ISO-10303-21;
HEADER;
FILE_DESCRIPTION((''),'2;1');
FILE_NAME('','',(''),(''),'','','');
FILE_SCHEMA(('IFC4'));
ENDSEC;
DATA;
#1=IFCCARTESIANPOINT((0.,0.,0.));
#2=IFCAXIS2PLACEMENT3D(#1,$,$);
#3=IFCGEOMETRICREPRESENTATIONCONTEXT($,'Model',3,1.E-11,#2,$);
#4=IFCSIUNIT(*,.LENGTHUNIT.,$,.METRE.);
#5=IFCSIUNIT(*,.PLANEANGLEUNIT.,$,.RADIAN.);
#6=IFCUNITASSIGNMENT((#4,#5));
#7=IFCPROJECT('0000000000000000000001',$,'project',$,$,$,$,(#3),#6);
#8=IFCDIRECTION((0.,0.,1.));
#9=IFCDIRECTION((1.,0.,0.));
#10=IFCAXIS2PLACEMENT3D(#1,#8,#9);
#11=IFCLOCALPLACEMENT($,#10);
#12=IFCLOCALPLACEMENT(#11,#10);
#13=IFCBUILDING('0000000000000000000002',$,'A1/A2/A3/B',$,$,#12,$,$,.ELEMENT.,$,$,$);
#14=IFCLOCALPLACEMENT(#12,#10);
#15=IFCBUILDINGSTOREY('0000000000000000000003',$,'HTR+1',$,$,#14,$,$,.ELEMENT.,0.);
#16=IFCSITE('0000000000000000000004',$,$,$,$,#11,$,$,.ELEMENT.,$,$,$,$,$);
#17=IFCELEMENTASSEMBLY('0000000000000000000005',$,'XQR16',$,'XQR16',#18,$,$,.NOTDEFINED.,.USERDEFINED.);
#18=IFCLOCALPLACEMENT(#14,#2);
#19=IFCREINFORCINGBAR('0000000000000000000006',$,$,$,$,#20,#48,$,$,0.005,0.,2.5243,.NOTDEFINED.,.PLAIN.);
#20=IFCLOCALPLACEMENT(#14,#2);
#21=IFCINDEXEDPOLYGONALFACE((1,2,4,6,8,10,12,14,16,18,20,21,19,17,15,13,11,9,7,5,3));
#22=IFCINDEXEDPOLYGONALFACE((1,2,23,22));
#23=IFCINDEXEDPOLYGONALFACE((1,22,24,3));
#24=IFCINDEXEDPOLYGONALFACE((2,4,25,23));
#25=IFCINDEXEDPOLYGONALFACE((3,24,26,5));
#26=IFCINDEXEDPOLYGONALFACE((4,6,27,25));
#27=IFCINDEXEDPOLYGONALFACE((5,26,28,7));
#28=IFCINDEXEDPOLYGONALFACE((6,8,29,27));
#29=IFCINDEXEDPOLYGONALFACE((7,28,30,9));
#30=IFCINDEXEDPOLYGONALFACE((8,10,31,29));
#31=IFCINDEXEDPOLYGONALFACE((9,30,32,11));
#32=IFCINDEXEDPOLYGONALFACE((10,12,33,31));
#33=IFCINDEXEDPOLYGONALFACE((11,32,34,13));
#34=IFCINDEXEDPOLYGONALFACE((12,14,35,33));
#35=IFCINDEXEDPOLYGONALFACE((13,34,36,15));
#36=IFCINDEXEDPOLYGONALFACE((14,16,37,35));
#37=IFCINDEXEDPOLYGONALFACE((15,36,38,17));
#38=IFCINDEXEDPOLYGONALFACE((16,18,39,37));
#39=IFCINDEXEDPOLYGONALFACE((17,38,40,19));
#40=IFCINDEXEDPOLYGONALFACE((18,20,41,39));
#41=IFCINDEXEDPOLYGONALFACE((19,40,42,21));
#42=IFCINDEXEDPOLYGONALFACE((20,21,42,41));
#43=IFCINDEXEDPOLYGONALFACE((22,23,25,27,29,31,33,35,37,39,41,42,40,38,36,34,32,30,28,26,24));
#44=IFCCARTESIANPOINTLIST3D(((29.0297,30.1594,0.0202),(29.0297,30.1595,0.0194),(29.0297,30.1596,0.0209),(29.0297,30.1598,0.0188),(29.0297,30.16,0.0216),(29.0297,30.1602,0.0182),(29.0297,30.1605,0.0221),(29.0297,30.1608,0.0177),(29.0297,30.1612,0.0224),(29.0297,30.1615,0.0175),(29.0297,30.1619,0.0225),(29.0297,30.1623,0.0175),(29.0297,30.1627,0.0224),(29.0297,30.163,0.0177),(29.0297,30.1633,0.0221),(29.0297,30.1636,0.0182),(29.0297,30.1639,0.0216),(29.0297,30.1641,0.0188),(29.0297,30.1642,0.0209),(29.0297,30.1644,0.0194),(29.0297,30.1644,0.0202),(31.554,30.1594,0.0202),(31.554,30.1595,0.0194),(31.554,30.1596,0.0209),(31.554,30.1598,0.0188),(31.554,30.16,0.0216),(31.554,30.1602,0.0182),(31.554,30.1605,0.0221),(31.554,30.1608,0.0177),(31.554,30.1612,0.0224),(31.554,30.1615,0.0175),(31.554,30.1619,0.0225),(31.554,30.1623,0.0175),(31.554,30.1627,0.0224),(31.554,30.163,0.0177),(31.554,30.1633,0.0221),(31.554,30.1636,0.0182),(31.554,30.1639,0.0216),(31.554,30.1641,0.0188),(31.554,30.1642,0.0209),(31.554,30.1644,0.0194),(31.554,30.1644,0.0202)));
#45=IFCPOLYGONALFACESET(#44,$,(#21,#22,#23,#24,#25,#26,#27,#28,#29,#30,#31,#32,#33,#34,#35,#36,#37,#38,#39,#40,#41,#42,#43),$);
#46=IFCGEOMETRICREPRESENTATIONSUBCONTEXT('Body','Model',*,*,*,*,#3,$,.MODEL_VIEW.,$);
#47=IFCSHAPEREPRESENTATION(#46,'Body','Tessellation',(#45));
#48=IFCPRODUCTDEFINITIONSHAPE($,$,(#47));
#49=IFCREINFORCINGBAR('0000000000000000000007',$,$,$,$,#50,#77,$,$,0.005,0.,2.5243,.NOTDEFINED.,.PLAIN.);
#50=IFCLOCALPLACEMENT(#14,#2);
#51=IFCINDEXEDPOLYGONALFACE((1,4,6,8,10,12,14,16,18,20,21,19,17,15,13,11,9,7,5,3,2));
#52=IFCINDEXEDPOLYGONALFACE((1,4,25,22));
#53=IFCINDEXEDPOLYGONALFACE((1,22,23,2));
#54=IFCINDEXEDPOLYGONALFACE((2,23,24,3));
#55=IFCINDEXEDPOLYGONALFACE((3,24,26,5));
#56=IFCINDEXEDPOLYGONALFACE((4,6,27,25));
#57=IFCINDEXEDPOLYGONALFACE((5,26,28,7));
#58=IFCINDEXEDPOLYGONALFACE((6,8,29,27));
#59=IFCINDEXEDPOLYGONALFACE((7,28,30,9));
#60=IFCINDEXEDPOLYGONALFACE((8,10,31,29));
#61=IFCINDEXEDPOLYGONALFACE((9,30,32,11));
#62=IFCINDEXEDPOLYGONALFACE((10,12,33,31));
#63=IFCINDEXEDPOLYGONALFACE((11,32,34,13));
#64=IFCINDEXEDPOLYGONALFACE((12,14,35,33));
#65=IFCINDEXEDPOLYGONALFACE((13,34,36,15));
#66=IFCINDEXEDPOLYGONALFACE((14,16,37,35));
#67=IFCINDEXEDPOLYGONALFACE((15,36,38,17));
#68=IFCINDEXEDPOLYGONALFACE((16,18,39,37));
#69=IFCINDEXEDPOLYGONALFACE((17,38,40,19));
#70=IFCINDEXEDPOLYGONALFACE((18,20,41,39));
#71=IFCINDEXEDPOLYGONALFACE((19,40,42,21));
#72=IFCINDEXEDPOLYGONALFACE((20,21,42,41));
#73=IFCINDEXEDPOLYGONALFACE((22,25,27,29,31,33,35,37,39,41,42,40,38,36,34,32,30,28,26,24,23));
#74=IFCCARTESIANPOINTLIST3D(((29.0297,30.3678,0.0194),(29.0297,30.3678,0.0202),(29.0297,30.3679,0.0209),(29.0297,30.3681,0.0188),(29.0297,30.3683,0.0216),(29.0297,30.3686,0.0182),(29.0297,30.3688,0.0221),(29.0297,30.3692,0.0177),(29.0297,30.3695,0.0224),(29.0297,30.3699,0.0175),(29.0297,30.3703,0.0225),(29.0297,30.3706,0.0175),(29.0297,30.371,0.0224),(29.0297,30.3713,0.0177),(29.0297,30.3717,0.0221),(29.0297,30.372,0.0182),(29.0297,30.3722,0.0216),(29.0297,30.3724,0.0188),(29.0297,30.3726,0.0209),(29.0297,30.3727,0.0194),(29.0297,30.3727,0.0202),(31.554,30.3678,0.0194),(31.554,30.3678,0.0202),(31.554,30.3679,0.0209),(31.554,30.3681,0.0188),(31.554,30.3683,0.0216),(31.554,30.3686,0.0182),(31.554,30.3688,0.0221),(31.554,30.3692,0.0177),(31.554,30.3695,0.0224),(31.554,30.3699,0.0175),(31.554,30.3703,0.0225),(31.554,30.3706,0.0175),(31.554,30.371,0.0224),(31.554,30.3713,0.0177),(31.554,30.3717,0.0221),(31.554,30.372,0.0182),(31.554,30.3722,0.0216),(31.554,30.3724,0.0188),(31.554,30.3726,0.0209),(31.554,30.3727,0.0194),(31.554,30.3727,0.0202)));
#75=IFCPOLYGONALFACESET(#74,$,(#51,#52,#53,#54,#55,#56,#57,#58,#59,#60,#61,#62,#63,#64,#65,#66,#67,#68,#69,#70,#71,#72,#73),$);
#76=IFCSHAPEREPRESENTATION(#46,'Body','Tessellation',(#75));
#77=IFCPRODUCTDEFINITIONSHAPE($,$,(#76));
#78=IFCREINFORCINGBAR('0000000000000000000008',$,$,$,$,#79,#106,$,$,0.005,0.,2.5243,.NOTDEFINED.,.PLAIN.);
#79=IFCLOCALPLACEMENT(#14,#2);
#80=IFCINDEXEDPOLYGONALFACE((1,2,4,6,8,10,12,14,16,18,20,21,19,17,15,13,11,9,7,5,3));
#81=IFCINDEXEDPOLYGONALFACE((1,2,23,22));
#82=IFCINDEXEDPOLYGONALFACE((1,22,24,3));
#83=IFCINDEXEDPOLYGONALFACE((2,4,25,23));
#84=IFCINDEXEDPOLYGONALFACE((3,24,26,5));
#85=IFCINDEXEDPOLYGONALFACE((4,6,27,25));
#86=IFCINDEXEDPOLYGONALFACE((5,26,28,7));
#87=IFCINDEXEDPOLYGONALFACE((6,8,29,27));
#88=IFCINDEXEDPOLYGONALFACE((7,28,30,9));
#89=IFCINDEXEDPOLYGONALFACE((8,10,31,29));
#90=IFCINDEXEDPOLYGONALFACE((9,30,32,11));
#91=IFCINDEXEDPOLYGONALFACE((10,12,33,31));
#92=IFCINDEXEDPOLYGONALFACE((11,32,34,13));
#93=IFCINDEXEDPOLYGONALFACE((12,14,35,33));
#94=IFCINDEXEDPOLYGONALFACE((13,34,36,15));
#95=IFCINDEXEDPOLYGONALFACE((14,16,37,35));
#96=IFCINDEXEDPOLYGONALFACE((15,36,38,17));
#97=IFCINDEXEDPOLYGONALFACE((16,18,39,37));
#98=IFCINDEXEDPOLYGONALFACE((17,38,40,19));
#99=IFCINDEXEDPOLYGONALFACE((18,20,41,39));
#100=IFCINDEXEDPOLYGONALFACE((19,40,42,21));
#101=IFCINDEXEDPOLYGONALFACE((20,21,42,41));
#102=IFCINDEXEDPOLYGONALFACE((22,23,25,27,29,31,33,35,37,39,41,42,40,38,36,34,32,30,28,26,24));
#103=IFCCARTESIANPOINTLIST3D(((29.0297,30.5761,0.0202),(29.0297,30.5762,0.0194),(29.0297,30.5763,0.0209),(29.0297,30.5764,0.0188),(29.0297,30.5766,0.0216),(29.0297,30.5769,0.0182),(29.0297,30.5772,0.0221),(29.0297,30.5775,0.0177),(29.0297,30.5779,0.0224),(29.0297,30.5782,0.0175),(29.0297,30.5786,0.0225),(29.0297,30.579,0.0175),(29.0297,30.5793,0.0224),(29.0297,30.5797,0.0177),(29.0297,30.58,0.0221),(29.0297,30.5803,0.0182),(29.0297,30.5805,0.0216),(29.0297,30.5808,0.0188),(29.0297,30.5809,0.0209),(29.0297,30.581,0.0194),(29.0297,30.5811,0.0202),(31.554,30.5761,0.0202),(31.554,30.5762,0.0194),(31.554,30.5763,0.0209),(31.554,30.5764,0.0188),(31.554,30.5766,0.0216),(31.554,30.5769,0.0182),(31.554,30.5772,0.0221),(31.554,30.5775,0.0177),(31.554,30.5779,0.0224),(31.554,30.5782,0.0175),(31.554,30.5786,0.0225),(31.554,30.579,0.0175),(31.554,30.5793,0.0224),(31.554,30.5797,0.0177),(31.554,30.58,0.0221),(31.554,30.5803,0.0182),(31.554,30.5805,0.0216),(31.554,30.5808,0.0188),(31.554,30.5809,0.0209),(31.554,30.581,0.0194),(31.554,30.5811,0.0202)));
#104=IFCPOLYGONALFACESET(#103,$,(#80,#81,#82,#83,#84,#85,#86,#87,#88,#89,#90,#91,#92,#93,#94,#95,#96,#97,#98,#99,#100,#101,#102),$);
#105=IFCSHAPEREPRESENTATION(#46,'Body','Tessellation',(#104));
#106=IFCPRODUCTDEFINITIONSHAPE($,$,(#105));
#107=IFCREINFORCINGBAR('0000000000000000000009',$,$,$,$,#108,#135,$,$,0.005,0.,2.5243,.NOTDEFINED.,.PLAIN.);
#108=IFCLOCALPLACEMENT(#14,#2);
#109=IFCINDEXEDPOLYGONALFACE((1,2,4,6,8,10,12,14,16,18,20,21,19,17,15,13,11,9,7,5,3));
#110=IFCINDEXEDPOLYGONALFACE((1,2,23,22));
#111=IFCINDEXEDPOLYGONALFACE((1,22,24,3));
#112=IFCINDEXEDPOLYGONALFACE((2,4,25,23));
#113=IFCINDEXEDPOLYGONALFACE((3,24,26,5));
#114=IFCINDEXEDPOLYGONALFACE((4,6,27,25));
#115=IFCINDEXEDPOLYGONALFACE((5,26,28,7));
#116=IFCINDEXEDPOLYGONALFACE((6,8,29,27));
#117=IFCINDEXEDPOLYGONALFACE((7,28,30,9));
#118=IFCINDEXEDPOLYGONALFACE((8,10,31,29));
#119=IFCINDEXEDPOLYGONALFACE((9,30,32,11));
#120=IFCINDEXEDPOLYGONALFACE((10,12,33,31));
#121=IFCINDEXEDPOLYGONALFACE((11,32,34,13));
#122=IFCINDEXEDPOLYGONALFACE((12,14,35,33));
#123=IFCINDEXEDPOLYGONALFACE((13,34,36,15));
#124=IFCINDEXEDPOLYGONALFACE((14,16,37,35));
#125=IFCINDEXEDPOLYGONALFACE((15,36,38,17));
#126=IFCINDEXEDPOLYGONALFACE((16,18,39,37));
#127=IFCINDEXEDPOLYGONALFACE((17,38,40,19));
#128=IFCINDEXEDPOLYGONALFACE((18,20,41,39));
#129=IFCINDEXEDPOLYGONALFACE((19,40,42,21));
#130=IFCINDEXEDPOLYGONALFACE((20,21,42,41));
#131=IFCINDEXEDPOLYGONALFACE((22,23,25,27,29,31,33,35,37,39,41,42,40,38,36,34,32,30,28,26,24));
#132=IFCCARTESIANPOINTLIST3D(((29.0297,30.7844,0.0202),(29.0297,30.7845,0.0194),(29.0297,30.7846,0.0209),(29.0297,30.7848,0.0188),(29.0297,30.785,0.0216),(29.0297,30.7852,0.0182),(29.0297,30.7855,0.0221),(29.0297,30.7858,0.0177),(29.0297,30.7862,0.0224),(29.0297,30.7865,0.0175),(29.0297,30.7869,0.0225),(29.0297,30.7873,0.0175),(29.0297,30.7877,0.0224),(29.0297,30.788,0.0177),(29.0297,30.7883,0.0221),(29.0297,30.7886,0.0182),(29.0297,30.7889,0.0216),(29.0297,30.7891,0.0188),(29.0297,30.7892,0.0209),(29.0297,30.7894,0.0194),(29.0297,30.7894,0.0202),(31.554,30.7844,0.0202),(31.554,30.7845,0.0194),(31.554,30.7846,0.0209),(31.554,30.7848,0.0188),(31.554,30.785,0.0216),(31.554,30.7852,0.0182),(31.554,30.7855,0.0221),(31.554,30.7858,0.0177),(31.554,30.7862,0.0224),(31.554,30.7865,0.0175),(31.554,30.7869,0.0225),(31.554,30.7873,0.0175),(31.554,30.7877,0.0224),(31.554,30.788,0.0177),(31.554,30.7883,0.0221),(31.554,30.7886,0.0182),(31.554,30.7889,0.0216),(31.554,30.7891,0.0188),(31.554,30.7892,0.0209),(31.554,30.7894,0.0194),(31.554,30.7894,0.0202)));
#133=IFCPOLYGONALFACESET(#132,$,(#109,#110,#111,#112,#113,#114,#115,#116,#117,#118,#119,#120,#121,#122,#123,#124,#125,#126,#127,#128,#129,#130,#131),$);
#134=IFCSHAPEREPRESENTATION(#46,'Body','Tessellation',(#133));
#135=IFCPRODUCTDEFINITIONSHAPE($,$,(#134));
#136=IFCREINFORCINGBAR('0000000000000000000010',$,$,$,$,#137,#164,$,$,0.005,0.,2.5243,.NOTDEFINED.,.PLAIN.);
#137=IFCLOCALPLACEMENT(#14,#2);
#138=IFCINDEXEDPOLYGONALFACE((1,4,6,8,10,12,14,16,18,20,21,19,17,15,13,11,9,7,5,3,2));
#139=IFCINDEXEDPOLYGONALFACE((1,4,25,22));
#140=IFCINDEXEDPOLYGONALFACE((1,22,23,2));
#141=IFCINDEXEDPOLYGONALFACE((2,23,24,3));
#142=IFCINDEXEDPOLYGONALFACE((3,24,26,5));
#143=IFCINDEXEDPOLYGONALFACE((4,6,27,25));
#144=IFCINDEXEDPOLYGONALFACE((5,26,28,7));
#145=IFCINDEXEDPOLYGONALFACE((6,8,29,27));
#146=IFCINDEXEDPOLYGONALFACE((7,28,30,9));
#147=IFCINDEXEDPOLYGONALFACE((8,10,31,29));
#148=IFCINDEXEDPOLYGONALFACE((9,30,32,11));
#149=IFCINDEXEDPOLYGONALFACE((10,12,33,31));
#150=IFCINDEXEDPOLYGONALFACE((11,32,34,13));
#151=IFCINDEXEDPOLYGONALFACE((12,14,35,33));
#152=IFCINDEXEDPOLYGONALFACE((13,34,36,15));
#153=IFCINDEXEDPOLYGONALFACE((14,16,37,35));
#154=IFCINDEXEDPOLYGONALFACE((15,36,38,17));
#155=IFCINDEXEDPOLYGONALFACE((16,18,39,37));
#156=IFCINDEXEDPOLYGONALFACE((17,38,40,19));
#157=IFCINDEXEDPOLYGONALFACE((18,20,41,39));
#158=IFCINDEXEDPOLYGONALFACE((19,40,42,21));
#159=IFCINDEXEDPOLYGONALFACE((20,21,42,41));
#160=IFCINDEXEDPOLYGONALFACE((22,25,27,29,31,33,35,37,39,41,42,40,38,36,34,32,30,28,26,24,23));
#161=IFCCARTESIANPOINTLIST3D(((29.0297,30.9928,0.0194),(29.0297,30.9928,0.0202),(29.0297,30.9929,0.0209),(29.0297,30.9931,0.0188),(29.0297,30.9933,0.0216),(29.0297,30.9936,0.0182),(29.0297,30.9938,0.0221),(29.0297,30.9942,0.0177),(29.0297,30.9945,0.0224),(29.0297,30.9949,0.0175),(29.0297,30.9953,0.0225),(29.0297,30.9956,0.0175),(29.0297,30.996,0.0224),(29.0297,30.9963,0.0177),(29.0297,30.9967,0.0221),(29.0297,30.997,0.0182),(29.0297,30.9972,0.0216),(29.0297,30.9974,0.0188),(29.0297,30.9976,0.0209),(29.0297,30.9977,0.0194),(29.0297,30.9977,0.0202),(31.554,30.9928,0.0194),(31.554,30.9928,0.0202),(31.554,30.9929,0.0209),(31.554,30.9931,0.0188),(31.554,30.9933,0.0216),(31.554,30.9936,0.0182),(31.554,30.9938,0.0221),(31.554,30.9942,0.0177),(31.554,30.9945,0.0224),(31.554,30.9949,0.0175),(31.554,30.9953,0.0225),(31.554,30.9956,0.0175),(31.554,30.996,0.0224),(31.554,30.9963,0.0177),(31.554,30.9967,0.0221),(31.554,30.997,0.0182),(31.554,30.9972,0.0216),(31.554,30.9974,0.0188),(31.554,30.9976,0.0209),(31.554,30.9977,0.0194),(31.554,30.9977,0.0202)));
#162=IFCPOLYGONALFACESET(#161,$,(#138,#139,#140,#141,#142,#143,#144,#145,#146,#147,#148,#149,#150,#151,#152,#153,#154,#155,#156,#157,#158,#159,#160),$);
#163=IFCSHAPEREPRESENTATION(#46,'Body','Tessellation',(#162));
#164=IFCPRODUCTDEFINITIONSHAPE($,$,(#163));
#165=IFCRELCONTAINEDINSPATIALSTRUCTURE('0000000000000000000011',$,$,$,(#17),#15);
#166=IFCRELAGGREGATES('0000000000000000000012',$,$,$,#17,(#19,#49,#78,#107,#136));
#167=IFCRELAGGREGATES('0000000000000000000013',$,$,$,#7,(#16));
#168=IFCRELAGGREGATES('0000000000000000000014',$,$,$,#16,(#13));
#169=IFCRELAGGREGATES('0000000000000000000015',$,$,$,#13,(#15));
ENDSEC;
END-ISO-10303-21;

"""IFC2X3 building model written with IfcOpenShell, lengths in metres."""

from ifc_helpers import new_model, entity, si_unit, origin, origin_with_axes, place, context, subcontext, project, spatial, shape, element, aggregate, save


model = new_model("IFC2X3")

# Units and contexts
model_context = context("Model", 3, precision=1e-11, world=origin())
body_context = subcontext(model_context, "Body", "Model", "MODEL_VIEW")
ifc_project = project(units=[si_unit("LENGTHUNIT", "METRE"), si_unit("PLANEANGLEUNIT", "RADIAN")], contexts=[model_context])

# Site, building, storey
site_placement = place(None, origin_with_axes())
site = spatial("IfcSite", under=ifc_project, at=site_placement, CompositionType="ELEMENT")
building_placement = place(site_placement, origin_with_axes())
building = spatial("IfcBuilding", under=site, at=building_placement, Name="A1/A2/A3/B", CompositionType="ELEMENT")
storey_placement = place(building_placement, origin_with_axes())
storey = spatial("IfcBuildingStorey", under=building, at=storey_placement, Name="HTR+1", CompositionType="ELEMENT", Elevation=0.0)

# Element assembly, reinforcing bars
assembly_1_placement = place(storey_placement, origin_with_axes())
assembly_1 = element("IfcElementAssembly", 1, at=assembly_1_placement, inside=storey, Name="XQR16", ObjectType="XQR16", AssemblyPlace="NOTDEFINED", PredefinedType="USERDEFINED")
reinforcing_bar_1_placement = place(assembly_1_placement, origin_with_axes())
reinforcing_bar_1 = element("IfcReinforcingBar", 2, at=reinforcing_bar_1_placement, BarLength=2.5243, BarRole="NOTDEFINED", BarSurface="PLAIN", CrossSectionArea=0.0, NominalDiameter=0.005, shapes=[
    shape(body_context, "Body", "AdvancedSweptSolid", [entity("IfcSweptDiskSolid", entity("IfcPolyline", [entity("IfcCartesianPoint", [29.0297, 30.1619, 0.02]), entity("IfcCartesianPoint", [31.554, 30.1619, 0.02])]), 0.0025, None, 0.0, 2.5243)]),
    shape(body_context, "Body", "AdvancedSweptSolid", [entity("IfcSweptDiskSolid", entity("IfcPolyline", [entity("IfcCartesianPoint", [29.0297, 30.1619, 0.02]), entity("IfcCartesianPoint", [31.554, 30.1619, 0.02])]), 0.0025, None, 0.0, 2.5243)]),
])
reinforcing_bar_2_placement = place(assembly_1_placement, origin_with_axes())
reinforcing_bar_2 = element("IfcReinforcingBar", 3, at=reinforcing_bar_2_placement, BarLength=2.5243, BarRole="NOTDEFINED", BarSurface="PLAIN", CrossSectionArea=0.0, NominalDiameter=0.005, shapes=[
    shape(body_context, "Body", "AdvancedSweptSolid", [entity("IfcSweptDiskSolid", entity("IfcPolyline", [entity("IfcCartesianPoint", [29.0297, 30.3703, 0.02]), entity("IfcCartesianPoint", [31.554, 30.3703, 0.02])]), 0.0025, None, 0.0, 2.5243)]),
    shape(body_context, "Body", "AdvancedSweptSolid", [entity("IfcSweptDiskSolid", entity("IfcPolyline", [entity("IfcCartesianPoint", [29.0297, 30.3703, 0.02]), entity("IfcCartesianPoint", [31.554, 30.3703, 0.02])]), 0.0025, None, 0.0, 2.5243)]),
])
reinforcing_bar_3_placement = place(assembly_1_placement, origin_with_axes())
reinforcing_bar_3 = element("IfcReinforcingBar", 4, at=reinforcing_bar_3_placement, BarLength=2.5243, BarRole="NOTDEFINED", BarSurface="PLAIN", CrossSectionArea=0.0, NominalDiameter=0.005, shapes=[
    shape(body_context, "Body", "AdvancedSweptSolid", [entity("IfcSweptDiskSolid", entity("IfcPolyline", [entity("IfcCartesianPoint", [29.0297, 30.5786, 0.02]), entity("IfcCartesianPoint", [31.554, 30.5786, 0.02])]), 0.0025, None, 0.0, 2.5243)]),
    shape(body_context, "Body", "AdvancedSweptSolid", [entity("IfcSweptDiskSolid", entity("IfcPolyline", [entity("IfcCartesianPoint", [29.0297, 30.5786, 0.02]), entity("IfcCartesianPoint", [31.554, 30.5786, 0.02])]), 0.0025, None, 0.0, 2.5243)]),
])
reinforcing_bar_4_placement = place(assembly_1_placement, origin_with_axes())
reinforcing_bar_4 = element("IfcReinforcingBar", 5, at=reinforcing_bar_4_placement, BarLength=2.5243, BarRole="NOTDEFINED", BarSurface="PLAIN", CrossSectionArea=0.0, NominalDiameter=0.005, shapes=[
    shape(body_context, "Body", "AdvancedSweptSolid", [entity("IfcSweptDiskSolid", entity("IfcPolyline", [entity("IfcCartesianPoint", [29.0297, 30.7869, 0.02]), entity("IfcCartesianPoint", [31.554, 30.7869, 0.02])]), 0.0025, None, 0.0, 2.5243)]),
    shape(body_context, "Body", "AdvancedSweptSolid", [entity("IfcSweptDiskSolid", entity("IfcPolyline", [entity("IfcCartesianPoint", [29.0297, 30.7869, 0.02]), entity("IfcCartesianPoint", [31.554, 30.7869, 0.02])]), 0.0025, None, 0.0, 2.5243)]),
])
reinforcing_bar_5_placement = place(assembly_1_placement, origin_with_axes())
reinforcing_bar_5 = element("IfcReinforcingBar", 6, at=reinforcing_bar_5_placement, BarLength=2.5243, BarRole="NOTDEFINED", BarSurface="PLAIN", CrossSectionArea=0.0, NominalDiameter=0.005, shapes=[
    shape(body_context, "Body", "AdvancedSweptSolid", [entity("IfcSweptDiskSolid", entity("IfcPolyline", [entity("IfcCartesianPoint", [29.0297, 30.9953, 0.02]), entity("IfcCartesianPoint", [31.554, 30.9953, 0.02])]), 0.0025, None, 0.0, 2.5243)]),
    shape(body_context, "Body", "AdvancedSweptSolid", [entity("IfcSweptDiskSolid", entity("IfcPolyline", [entity("IfcCartesianPoint", [29.0297, 30.9953, 0.02]), entity("IfcCartesianPoint", [31.554, 30.9953, 0.02])]), 0.0025, None, 0.0, 2.5243)]),
])
aggregate(assembly_1, [reinforcing_bar_1, reinforcing_bar_2, reinforcing_bar_3, reinforcing_bar_4, reinforcing_bar_5])

save(model, "model.ifc")
